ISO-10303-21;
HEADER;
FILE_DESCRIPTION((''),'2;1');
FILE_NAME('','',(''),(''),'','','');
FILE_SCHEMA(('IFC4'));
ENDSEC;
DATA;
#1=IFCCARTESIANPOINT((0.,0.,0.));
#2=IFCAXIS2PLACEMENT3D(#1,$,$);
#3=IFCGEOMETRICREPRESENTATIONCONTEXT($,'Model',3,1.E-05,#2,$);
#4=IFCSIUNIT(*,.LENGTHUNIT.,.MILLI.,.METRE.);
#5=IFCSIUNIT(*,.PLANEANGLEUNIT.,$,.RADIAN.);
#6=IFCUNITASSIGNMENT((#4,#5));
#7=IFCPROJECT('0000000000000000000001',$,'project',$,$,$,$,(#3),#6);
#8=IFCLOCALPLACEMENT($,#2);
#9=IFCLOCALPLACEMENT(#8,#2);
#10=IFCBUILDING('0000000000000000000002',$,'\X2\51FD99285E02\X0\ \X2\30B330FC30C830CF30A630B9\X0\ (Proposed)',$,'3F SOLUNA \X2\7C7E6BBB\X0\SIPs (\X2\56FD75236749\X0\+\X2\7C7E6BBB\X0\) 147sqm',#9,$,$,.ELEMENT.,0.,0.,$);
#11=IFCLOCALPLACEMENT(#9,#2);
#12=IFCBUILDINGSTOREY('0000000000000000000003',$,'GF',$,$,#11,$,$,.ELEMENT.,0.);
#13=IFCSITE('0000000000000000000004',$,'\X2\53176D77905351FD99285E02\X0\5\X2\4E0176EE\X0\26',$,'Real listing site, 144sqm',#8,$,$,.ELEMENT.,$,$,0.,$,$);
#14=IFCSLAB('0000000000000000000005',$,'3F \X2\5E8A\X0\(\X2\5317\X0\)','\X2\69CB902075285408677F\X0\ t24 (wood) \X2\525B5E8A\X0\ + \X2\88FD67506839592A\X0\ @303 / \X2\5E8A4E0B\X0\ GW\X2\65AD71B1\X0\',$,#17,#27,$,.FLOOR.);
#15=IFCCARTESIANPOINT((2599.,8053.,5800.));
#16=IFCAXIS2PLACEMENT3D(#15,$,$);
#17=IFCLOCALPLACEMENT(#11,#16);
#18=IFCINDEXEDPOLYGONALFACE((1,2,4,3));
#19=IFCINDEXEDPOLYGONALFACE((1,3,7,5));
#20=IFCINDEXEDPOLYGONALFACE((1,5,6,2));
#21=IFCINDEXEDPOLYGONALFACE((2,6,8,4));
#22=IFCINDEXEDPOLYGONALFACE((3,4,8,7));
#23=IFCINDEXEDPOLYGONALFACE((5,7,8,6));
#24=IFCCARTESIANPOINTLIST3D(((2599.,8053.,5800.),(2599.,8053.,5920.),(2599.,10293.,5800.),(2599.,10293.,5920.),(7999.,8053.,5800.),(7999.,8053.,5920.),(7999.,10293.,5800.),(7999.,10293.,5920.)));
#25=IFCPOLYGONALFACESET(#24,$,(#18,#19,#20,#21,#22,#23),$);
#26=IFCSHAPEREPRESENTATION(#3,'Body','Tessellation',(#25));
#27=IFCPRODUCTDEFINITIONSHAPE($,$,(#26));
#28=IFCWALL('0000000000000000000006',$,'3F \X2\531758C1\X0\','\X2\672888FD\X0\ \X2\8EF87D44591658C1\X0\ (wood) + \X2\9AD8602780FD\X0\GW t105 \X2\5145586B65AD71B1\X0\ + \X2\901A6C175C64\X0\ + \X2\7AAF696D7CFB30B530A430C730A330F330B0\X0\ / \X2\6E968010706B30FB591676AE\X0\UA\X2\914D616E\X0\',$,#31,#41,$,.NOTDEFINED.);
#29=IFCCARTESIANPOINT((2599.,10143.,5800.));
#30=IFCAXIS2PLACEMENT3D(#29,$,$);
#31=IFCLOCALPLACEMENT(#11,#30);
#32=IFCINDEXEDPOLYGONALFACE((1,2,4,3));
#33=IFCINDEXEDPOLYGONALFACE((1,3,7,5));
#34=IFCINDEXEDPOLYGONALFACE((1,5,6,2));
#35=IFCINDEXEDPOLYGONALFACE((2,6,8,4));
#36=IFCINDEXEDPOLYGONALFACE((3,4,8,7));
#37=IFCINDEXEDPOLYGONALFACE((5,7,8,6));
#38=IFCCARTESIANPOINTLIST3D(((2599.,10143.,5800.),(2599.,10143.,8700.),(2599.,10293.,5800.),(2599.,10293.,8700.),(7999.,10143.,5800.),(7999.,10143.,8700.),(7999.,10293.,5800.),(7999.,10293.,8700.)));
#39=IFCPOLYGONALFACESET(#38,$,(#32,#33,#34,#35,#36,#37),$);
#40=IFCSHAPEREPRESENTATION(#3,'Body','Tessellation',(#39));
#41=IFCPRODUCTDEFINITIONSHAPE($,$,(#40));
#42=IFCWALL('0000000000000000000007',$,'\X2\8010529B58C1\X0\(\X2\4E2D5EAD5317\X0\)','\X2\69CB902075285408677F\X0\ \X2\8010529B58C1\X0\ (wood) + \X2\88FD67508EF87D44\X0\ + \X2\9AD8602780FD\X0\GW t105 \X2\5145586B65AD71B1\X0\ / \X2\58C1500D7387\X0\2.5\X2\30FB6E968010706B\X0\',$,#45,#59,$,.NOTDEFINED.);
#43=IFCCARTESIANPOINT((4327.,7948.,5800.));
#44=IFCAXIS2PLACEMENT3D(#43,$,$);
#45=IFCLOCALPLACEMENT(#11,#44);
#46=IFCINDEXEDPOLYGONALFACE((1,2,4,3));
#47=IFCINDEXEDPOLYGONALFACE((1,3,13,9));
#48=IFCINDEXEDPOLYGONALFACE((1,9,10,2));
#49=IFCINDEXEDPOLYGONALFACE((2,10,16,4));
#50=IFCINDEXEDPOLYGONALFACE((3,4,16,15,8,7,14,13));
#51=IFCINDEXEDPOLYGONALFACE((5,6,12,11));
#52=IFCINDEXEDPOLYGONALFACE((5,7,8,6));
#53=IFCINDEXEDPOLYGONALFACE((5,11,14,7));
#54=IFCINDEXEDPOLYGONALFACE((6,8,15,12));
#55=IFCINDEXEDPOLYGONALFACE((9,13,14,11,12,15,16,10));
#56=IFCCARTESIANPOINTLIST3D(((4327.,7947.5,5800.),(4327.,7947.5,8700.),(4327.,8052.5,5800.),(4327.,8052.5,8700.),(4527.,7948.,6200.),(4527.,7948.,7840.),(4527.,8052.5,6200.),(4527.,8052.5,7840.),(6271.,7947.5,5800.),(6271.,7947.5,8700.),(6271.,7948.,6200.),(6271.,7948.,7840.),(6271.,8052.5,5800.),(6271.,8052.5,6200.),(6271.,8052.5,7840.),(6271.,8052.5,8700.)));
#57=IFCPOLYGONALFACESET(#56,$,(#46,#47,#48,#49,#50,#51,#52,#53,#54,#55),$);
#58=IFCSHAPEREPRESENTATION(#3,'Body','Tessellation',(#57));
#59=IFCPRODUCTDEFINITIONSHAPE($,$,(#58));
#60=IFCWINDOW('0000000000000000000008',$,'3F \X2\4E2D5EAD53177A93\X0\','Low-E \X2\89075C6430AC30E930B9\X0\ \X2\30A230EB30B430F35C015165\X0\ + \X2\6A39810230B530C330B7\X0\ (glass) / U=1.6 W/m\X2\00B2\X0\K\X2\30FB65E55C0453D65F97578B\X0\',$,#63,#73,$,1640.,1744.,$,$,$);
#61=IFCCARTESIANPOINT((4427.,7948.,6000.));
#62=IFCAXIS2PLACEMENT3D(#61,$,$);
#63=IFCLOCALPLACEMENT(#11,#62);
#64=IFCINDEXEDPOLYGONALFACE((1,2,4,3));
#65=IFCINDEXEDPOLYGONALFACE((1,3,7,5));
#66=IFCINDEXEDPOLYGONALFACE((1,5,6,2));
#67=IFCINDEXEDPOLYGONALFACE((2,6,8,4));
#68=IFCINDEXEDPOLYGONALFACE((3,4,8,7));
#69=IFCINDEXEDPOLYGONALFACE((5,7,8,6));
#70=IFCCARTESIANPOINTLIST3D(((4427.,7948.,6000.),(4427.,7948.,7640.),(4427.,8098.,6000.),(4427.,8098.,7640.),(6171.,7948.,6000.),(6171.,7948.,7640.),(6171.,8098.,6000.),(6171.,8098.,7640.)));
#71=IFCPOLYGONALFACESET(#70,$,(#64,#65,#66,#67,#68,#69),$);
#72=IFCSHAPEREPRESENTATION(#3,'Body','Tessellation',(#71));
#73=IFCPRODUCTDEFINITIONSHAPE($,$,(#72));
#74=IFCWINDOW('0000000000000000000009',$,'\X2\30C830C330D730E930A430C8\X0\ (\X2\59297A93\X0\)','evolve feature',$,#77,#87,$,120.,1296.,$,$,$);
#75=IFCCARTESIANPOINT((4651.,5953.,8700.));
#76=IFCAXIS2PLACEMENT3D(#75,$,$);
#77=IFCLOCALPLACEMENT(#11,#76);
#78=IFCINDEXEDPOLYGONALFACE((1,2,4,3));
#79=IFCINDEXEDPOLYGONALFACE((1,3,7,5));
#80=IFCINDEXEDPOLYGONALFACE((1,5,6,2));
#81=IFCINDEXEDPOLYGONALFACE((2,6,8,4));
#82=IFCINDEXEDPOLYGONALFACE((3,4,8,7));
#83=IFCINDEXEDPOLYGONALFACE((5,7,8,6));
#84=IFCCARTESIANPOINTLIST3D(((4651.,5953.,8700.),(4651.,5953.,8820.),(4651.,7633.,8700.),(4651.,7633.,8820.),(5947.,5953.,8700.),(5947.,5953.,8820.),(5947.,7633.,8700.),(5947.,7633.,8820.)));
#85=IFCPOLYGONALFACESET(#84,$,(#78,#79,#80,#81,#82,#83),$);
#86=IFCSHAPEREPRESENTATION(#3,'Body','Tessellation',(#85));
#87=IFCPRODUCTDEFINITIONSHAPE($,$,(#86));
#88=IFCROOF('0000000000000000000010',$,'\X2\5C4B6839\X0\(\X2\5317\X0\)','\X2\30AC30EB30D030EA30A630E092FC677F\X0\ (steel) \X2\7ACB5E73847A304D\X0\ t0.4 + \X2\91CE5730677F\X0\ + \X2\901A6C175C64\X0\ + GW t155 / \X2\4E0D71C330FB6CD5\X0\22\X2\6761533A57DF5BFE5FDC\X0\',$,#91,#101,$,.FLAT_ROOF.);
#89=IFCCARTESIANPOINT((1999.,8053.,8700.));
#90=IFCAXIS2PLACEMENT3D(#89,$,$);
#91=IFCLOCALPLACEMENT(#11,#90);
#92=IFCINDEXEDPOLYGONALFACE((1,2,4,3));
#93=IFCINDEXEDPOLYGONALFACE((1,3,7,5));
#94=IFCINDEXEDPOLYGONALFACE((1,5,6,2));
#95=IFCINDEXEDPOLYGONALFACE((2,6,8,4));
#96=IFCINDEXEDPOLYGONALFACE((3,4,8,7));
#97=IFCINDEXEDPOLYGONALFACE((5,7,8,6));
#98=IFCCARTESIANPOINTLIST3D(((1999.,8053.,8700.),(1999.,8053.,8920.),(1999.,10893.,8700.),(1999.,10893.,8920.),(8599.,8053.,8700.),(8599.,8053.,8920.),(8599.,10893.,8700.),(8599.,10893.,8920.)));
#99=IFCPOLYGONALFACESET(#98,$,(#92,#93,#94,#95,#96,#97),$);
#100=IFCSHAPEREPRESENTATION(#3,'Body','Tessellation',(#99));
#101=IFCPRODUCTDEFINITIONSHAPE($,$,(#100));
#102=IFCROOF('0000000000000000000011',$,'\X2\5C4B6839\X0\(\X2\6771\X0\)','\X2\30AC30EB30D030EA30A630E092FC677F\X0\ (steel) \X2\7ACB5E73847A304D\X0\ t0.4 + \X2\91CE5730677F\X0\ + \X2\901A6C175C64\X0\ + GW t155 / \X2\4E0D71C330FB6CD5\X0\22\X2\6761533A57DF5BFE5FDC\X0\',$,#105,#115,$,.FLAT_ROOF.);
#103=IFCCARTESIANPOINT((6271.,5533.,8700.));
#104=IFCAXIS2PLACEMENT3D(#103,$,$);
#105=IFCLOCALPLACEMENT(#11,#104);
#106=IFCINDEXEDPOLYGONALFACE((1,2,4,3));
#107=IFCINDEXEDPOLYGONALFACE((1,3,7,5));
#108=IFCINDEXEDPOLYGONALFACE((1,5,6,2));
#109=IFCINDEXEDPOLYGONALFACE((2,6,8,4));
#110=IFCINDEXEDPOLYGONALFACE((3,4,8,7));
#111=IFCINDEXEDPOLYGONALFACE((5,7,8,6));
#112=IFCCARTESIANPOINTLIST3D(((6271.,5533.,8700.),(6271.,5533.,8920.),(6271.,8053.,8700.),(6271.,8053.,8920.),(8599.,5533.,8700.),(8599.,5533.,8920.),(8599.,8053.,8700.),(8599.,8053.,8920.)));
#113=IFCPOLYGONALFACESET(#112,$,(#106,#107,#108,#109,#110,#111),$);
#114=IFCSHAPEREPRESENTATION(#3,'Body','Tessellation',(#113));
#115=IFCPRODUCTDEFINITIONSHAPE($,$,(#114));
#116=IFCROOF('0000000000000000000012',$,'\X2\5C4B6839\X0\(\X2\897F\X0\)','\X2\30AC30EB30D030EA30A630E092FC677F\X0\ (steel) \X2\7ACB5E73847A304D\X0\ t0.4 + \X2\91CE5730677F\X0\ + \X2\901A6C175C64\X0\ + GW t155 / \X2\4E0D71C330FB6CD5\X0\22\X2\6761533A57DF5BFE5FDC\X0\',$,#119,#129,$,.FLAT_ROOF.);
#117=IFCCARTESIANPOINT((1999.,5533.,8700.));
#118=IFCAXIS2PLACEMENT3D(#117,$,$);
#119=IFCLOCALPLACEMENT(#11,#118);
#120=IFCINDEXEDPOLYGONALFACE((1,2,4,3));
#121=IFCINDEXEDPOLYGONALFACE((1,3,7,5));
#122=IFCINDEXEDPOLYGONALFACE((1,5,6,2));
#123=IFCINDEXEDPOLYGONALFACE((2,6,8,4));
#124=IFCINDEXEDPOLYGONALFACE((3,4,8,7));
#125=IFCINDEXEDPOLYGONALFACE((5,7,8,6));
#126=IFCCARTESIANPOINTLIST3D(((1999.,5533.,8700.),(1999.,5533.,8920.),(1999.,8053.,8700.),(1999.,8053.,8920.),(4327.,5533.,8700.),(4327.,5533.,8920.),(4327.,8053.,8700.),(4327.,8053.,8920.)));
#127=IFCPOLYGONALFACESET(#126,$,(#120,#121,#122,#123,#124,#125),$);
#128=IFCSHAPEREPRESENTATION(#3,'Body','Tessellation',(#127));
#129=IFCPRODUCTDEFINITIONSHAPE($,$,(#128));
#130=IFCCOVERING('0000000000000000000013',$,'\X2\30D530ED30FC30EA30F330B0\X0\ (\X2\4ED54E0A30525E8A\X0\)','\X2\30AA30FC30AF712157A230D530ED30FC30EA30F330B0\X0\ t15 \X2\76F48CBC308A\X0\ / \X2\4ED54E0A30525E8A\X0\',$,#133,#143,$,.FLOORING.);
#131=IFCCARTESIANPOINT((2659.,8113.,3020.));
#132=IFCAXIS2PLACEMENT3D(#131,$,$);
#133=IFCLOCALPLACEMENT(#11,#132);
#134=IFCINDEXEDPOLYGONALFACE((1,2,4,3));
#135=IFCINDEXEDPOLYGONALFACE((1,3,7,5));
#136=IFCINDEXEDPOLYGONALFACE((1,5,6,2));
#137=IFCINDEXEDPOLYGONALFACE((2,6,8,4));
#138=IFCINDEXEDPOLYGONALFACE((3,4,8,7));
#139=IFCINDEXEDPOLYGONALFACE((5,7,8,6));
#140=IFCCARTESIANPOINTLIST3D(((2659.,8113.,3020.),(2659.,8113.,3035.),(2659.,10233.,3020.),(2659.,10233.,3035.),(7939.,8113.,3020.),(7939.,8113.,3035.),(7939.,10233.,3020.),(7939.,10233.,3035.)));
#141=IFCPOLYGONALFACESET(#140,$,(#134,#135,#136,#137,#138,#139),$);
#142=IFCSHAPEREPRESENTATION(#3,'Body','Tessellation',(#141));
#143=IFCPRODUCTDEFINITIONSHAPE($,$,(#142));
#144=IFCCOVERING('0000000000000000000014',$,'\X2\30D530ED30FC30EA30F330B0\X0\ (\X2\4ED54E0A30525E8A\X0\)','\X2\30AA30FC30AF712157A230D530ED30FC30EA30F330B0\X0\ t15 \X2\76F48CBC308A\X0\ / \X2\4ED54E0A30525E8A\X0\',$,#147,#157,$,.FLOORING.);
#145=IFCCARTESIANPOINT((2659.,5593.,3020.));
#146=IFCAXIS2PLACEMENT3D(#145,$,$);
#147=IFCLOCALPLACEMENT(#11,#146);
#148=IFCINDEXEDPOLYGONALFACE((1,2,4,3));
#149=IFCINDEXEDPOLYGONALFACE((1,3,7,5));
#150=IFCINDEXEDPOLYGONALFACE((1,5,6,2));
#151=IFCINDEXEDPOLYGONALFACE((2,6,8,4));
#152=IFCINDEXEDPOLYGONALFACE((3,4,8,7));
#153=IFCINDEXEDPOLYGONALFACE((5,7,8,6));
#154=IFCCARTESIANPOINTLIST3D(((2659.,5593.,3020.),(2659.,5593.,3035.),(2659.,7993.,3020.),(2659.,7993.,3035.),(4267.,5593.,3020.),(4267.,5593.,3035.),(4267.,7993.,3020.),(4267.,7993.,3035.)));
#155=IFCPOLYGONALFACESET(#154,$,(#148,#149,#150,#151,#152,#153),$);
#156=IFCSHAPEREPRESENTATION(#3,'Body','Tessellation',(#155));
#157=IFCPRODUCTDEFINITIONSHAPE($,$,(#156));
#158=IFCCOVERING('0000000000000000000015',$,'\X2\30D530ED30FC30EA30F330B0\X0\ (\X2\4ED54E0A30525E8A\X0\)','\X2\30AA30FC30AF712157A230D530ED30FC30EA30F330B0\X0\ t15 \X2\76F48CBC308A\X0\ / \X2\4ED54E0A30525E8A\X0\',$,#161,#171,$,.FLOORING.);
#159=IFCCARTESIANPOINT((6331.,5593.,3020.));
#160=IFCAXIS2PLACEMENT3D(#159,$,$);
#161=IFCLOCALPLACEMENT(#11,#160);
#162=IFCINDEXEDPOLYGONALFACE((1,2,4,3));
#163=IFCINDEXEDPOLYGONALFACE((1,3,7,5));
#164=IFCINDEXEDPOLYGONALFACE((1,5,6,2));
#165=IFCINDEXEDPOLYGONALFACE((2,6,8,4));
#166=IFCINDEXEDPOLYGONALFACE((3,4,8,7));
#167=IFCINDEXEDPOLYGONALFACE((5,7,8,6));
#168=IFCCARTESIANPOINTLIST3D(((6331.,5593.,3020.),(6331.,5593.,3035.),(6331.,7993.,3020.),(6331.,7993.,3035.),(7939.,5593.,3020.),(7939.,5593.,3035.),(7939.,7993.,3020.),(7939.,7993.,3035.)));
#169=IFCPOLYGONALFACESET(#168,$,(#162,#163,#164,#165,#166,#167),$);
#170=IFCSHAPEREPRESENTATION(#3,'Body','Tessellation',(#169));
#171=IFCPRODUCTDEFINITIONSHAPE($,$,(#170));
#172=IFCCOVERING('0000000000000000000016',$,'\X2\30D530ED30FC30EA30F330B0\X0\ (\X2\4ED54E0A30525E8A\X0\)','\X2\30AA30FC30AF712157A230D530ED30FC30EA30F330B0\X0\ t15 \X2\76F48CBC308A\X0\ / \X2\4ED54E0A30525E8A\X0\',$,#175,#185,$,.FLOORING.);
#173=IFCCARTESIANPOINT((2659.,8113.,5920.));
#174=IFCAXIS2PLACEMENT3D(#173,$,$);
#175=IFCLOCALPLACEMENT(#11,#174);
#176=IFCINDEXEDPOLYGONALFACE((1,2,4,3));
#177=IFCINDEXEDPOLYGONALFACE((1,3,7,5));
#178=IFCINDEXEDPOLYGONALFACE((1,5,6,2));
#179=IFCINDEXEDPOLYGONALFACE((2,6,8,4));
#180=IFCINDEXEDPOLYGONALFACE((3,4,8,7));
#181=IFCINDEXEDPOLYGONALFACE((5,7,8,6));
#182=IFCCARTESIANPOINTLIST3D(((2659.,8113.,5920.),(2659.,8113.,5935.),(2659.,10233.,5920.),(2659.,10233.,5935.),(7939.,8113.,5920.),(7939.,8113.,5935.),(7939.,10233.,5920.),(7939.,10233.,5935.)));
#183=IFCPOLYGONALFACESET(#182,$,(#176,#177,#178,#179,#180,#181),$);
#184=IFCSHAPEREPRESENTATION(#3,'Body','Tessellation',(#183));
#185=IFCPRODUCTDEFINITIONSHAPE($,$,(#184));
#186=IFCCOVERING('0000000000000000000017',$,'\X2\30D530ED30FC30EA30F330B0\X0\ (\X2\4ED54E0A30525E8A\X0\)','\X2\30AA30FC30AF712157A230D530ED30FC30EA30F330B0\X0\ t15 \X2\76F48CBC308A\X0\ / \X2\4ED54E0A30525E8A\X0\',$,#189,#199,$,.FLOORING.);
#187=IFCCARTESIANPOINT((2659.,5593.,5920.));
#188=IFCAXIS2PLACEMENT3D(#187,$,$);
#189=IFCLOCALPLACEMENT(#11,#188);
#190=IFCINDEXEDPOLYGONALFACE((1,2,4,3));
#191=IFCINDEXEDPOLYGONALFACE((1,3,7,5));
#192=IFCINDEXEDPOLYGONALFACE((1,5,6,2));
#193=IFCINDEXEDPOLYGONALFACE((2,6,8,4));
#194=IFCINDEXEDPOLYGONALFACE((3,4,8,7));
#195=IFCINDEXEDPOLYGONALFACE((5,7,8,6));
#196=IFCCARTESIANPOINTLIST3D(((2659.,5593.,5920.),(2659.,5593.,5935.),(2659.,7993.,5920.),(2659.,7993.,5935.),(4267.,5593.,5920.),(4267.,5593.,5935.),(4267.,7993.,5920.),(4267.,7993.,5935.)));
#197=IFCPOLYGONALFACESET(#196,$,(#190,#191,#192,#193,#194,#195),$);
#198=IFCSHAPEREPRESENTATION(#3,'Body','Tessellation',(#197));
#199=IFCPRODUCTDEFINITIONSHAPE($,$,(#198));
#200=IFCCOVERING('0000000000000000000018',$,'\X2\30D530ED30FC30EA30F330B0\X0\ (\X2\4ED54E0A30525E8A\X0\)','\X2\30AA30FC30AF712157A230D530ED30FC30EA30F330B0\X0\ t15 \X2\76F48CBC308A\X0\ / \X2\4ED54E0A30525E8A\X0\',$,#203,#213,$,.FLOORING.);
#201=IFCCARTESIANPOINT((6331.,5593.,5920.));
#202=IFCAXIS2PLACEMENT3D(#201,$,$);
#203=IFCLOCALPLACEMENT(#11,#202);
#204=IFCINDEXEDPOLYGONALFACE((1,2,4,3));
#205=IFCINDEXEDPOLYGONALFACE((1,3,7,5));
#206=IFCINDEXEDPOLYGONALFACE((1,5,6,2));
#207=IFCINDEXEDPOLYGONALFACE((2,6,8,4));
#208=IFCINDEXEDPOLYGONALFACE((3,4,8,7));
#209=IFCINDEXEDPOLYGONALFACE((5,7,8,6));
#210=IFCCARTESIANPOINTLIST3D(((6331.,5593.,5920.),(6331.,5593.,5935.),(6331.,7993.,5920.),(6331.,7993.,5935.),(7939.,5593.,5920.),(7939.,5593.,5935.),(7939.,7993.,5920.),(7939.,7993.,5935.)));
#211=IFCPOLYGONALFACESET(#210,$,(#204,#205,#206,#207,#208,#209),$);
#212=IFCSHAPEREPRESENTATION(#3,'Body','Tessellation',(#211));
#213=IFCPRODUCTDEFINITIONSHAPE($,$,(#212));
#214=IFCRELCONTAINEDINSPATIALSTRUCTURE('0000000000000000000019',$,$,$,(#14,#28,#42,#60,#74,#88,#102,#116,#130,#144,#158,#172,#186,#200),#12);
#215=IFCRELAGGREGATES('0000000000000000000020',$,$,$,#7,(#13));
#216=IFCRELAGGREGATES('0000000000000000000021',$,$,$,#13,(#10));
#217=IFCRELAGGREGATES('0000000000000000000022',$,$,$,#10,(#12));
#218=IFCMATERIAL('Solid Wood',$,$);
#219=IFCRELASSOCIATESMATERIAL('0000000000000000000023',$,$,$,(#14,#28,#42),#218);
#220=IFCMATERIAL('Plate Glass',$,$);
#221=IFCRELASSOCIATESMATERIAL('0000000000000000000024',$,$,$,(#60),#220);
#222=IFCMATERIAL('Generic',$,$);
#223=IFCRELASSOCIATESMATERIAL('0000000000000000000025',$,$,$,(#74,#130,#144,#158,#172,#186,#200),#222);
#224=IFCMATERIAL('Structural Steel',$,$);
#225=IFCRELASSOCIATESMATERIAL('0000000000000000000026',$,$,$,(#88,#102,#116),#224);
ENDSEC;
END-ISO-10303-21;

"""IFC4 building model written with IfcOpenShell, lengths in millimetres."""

from ifc_helpers import new_model, si_unit, frame, frame_2d, origin, place, context, project, spatial, rectangle, extrude, material, element, fill, save


model = new_model("IFC4")

# Units and contexts
model_context = context("Model", 3, precision=1e-05, world=origin())
ifc_project = project(units=[si_unit("LENGTHUNIT", "METRE", prefix="MILLI"), si_unit("PLANEANGLEUNIT", "RADIAN")], contexts=[model_context])

# Site, building, storey
site_placement = place(None, origin())
site = spatial("IfcSite", under=ifc_project, at=site_placement, Name="北海道函館市5丁目26", ObjectType="Real listing site, 144sqm", CompositionType="ELEMENT", RefElevation=0.0)
building_placement = place(site_placement, origin())
building = spatial("IfcBuilding", under=site, at=building_placement, Name="函館市 コートハウス (Proposed)", ObjectType="3F SOLUNA 籾殻SIPs (国産杉+籾殻) 147sqm", CompositionType="ELEMENT", ElevationOfRefHeight=0.0, ElevationOfTerrain=0.0)
storey_placement = place(building_placement, origin())
storey = spatial("IfcBuildingStorey", under=building, at=storey_placement, Name="GF", CompositionType="ELEMENT", Elevation=0.0)

# Slab
ifc_material_1 = material(Name="Solid Wood")
slab_placement = place(storey_placement, frame((2599.0, 8053.0, 5800.0)))
element("IfcSlab", 1, at=slab_placement, inside=storey, material=ifc_material_1, Name="3F 床(北)", Description="構造用合板 t24 (wood) 剛床 + 製材根太 @303 / 床下 GW断熱", PredefinedType="FLOOR", context=model_context, shape_type="SweptSolid", body=[
    extrude(rectangle(XDim=5400.0, YDim=2240.0, at=frame_2d((2700.0, 1120.0))), frame((2599.0, 8053.0, 5800.0)), (0.0, 0.0, 1.0), 120.0),
])

# Wall
wall_1_placement = place(storey_placement, frame((2599.0, 10143.0, 5800.0)))
element("IfcWall", 2, at=wall_1_placement, inside=storey, material=ifc_material_1, Name="3F 北壁", Description="木製 軸組外壁 (wood) + 高性能GW t105 充填断熱 + 通気層 + 窯業系サイディング / 準耐火・外皮UA配慮", PredefinedType="NOTDEFINED", context=model_context, shape_type="SweptSolid", body=[
    extrude(rectangle(XDim=5400.0, YDim=150.0, at=frame_2d((2700.0, 75.0))), frame((2599.0, 10143.0, 5800.0)), (0.0, 0.0, 1.0), 2900.0),
])

# Wall, opening, window
wall_2_placement = place(storey_placement, frame((4327.0, 7948.0, 5800.0)))
wall_2 = element("IfcWall", 3, at=wall_2_placement, inside=storey, material=ifc_material_1, Name="耐力壁(中庭北)", Description="構造用合板 耐力壁 (wood) + 製材軸組 + 高性能GW t105 充填断熱 / 壁倍率2.5・準耐火", PredefinedType="NOTDEFINED", context=model_context, shape_type="SweptSolid", body=[
    extrude(rectangle(XDim=1944.0, YDim=105.0, at=frame_2d((972.0, 52.0))), frame((4327.0, 7948.0, 5800.0)), (0.0, 0.0, 1.0), 2900.0),
])
opening_placement = place(storey_placement, frame((4427.0, 7948.0, 6000.0)))
opening = element("IfcOpeningElement", 4, at=opening_placement, cuts=wall_2, PredefinedType="NOTDEFINED", context=model_context, shape_type="SweptSolid", body=[
    extrude(rectangle(XDim=1744.0, YDim=150.0, at=frame_2d((872.0, 75.0))), frame((4427.0, 7948.0, 6000.0)), (0.0, 0.0, 1.0), 1640.0),
])
ifc_material_2 = material(Name="Plate Glass")
window_1_placement = place(storey_placement, frame((4427.0, 7948.0, 6000.0)))
window_1 = element("IfcWindow", 5, at=window_1_placement, inside=storey, material=ifc_material_2, Name="3F 中庭北窓", Description="Low-E 複層ガラス アルゴン封入 + 樹脂サッシ (glass) / U=1.6 W/m²K・日射取得型", OverallHeight=1640.0, OverallWidth=1744.0, context=model_context, shape_type="SweptSolid", body=[
    extrude(rectangle(XDim=1744.0, YDim=150.0, at=frame_2d((872.0, 75.0))), frame((4427.0, 7948.0, 6000.0)), (0.0, 0.0, 1.0), 1640.0),
])
fill(opening, window_1)

# Window
ifc_material_3 = material(Name="Generic")
window_2_placement = place(storey_placement, frame((4651.0, 5953.0, 8700.0)))
element("IfcWindow", 6, at=window_2_placement, inside=storey, material=ifc_material_3, Name="トップライト (天窓)", Description="evolve feature", OverallHeight=120.0, OverallWidth=1296.0, context=model_context, shape_type="SweptSolid", body=[
    extrude(rectangle(XDim=1296.0, YDim=1680.0, at=frame_2d((648.0, 840.0))), frame((4651.0, 5953.0, 8700.0)), (0.0, 0.0, 1.0), 120.0),
])

# Roofs
ifc_material_4 = material(Name="Structural Steel")
roof_1_placement = place(storey_placement, frame((1999.0, 8053.0, 8700.0)))
element("IfcRoof", 7, at=roof_1_placement, inside=storey, material=ifc_material_4, Name="屋根(北)", Description="ガルバリウム鋼板 (steel) 立平葺き t0.4 + 野地板 + 通気層 + GW t155 / 不燃・法22条区域対応", PredefinedType="FLAT_ROOF", context=model_context, shape_type="SweptSolid", body=[
    extrude(rectangle(XDim=6600.0, YDim=2840.0, at=frame_2d((3300.0, 1420.0))), frame((1999.0, 8053.0, 8700.0)), (0.0, 0.0, 1.0), 220.0),
])
roof_2_placement = place(storey_placement, frame((6271.0, 5533.0, 8700.0)))
element("IfcRoof", 8, at=roof_2_placement, inside=storey, material=ifc_material_4, Name="屋根(東)", Description="ガルバリウム鋼板 (steel) 立平葺き t0.4 + 野地板 + 通気層 + GW t155 / 不燃・法22条区域対応", PredefinedType="FLAT_ROOF", context=model_context, shape_type="SweptSolid", body=[
    extrude(rectangle(XDim=2328.0, YDim=2520.0, at=frame_2d((1164.0, 1260.0))), frame((6271.0, 5533.0, 8700.0)), (0.0, 0.0, 1.0), 220.0),
])
roof_3_placement = place(storey_placement, frame((1999.0, 5533.0, 8700.0)))
element("IfcRoof", 9, at=roof_3_placement, inside=storey, material=ifc_material_4, Name="屋根(西)", Description="ガルバリウム鋼板 (steel) 立平葺き t0.4 + 野地板 + 通気層 + GW t155 / 不燃・法22条区域対応", PredefinedType="FLAT_ROOF", context=model_context, shape_type="SweptSolid", body=[
    extrude(rectangle(XDim=2328.0, YDim=2520.0, at=frame_2d((1164.0, 1260.0))), frame((1999.0, 5533.0, 8700.0)), (0.0, 0.0, 1.0), 220.0),
])

# Coverings
covering_1_placement = place(storey_placement, frame((2659.0, 8113.0, 3020.0)))
element("IfcCovering", 10, at=covering_1_placement, inside=storey, material=ifc_material_3, Name="フローリング (仕上げ床)", Description="オーク無垢フローリング t15 直貼り / 仕上げ床", PredefinedType="FLOORING", context=model_context, shape_type="SweptSolid", body=[
    extrude(rectangle(XDim=5280.0, YDim=2120.0, at=frame_2d((2640.0, 1060.0))), frame((2659.0, 8113.0, 3020.0)), (0.0, 0.0, 1.0), 15.0),
])
covering_2_placement = place(storey_placement, frame((2659.0, 5593.0, 3020.0)))
element("IfcCovering", 11, at=covering_2_placement, inside=storey, material=ifc_material_3, Name="フローリング (仕上げ床)", Description="オーク無垢フローリング t15 直貼り / 仕上げ床", PredefinedType="FLOORING", context=model_context, shape_type="SweptSolid", body=[
    extrude(rectangle(XDim=1608.0, YDim=2400.0, at=frame_2d((804.0, 1200.0))), frame((2659.0, 5593.0, 3020.0)), (0.0, 0.0, 1.0), 15.0),
])
covering_3_placement = place(storey_placement, frame((6331.0, 5593.0, 3020.0)))
element("IfcCovering", 12, at=covering_3_placement, inside=storey, material=ifc_material_3, Name="フローリング (仕上げ床)", Description="オーク無垢フローリング t15 直貼り / 仕上げ床", PredefinedType="FLOORING", context=model_context, shape_type="SweptSolid", body=[
    extrude(rectangle(XDim=1608.0, YDim=2400.0, at=frame_2d((804.0, 1200.0))), frame((6331.0, 5593.0, 3020.0)), (0.0, 0.0, 1.0), 15.0),
])
covering_4_placement = place(storey_placement, frame((2659.0, 8113.0, 5920.0)))
element("IfcCovering", 13, at=covering_4_placement, inside=storey, material=ifc_material_3, Name="フローリング (仕上げ床)", Description="オーク無垢フローリング t15 直貼り / 仕上げ床", PredefinedType="FLOORING", context=model_context, shape_type="SweptSolid", body=[
    extrude(rectangle(XDim=5280.0, YDim=2120.0, at=frame_2d((2640.0, 1060.0))), frame((2659.0, 8113.0, 5920.0)), (0.0, 0.0, 1.0), 15.0),
])
covering_5_placement = place(storey_placement, frame((2659.0, 5593.0, 5920.0)))
element("IfcCovering", 14, at=covering_5_placement, inside=storey, material=ifc_material_3, Name="フローリング (仕上げ床)", Description="オーク無垢フローリング t15 直貼り / 仕上げ床", PredefinedType="FLOORING", context=model_context, shape_type="SweptSolid", body=[
    extrude(rectangle(XDim=1608.0, YDim=2400.0, at=frame_2d((804.0, 1200.0))), frame((2659.0, 5593.0, 5920.0)), (0.0, 0.0, 1.0), 15.0),
])
covering_6_placement = place(storey_placement, frame((6331.0, 5593.0, 5920.0)))
element("IfcCovering", 15, at=covering_6_placement, inside=storey, material=ifc_material_3, Name="フローリング (仕上げ床)", Description="オーク無垢フローリング t15 直貼り / 仕上げ床", PredefinedType="FLOORING", context=model_context, shape_type="SweptSolid", body=[
    extrude(rectangle(XDim=1608.0, YDim=2400.0, at=frame_2d((804.0, 1200.0))), frame((6331.0, 5593.0, 5920.0)), (0.0, 0.0, 1.0), 15.0),
])

save(model, "model.ifc")
